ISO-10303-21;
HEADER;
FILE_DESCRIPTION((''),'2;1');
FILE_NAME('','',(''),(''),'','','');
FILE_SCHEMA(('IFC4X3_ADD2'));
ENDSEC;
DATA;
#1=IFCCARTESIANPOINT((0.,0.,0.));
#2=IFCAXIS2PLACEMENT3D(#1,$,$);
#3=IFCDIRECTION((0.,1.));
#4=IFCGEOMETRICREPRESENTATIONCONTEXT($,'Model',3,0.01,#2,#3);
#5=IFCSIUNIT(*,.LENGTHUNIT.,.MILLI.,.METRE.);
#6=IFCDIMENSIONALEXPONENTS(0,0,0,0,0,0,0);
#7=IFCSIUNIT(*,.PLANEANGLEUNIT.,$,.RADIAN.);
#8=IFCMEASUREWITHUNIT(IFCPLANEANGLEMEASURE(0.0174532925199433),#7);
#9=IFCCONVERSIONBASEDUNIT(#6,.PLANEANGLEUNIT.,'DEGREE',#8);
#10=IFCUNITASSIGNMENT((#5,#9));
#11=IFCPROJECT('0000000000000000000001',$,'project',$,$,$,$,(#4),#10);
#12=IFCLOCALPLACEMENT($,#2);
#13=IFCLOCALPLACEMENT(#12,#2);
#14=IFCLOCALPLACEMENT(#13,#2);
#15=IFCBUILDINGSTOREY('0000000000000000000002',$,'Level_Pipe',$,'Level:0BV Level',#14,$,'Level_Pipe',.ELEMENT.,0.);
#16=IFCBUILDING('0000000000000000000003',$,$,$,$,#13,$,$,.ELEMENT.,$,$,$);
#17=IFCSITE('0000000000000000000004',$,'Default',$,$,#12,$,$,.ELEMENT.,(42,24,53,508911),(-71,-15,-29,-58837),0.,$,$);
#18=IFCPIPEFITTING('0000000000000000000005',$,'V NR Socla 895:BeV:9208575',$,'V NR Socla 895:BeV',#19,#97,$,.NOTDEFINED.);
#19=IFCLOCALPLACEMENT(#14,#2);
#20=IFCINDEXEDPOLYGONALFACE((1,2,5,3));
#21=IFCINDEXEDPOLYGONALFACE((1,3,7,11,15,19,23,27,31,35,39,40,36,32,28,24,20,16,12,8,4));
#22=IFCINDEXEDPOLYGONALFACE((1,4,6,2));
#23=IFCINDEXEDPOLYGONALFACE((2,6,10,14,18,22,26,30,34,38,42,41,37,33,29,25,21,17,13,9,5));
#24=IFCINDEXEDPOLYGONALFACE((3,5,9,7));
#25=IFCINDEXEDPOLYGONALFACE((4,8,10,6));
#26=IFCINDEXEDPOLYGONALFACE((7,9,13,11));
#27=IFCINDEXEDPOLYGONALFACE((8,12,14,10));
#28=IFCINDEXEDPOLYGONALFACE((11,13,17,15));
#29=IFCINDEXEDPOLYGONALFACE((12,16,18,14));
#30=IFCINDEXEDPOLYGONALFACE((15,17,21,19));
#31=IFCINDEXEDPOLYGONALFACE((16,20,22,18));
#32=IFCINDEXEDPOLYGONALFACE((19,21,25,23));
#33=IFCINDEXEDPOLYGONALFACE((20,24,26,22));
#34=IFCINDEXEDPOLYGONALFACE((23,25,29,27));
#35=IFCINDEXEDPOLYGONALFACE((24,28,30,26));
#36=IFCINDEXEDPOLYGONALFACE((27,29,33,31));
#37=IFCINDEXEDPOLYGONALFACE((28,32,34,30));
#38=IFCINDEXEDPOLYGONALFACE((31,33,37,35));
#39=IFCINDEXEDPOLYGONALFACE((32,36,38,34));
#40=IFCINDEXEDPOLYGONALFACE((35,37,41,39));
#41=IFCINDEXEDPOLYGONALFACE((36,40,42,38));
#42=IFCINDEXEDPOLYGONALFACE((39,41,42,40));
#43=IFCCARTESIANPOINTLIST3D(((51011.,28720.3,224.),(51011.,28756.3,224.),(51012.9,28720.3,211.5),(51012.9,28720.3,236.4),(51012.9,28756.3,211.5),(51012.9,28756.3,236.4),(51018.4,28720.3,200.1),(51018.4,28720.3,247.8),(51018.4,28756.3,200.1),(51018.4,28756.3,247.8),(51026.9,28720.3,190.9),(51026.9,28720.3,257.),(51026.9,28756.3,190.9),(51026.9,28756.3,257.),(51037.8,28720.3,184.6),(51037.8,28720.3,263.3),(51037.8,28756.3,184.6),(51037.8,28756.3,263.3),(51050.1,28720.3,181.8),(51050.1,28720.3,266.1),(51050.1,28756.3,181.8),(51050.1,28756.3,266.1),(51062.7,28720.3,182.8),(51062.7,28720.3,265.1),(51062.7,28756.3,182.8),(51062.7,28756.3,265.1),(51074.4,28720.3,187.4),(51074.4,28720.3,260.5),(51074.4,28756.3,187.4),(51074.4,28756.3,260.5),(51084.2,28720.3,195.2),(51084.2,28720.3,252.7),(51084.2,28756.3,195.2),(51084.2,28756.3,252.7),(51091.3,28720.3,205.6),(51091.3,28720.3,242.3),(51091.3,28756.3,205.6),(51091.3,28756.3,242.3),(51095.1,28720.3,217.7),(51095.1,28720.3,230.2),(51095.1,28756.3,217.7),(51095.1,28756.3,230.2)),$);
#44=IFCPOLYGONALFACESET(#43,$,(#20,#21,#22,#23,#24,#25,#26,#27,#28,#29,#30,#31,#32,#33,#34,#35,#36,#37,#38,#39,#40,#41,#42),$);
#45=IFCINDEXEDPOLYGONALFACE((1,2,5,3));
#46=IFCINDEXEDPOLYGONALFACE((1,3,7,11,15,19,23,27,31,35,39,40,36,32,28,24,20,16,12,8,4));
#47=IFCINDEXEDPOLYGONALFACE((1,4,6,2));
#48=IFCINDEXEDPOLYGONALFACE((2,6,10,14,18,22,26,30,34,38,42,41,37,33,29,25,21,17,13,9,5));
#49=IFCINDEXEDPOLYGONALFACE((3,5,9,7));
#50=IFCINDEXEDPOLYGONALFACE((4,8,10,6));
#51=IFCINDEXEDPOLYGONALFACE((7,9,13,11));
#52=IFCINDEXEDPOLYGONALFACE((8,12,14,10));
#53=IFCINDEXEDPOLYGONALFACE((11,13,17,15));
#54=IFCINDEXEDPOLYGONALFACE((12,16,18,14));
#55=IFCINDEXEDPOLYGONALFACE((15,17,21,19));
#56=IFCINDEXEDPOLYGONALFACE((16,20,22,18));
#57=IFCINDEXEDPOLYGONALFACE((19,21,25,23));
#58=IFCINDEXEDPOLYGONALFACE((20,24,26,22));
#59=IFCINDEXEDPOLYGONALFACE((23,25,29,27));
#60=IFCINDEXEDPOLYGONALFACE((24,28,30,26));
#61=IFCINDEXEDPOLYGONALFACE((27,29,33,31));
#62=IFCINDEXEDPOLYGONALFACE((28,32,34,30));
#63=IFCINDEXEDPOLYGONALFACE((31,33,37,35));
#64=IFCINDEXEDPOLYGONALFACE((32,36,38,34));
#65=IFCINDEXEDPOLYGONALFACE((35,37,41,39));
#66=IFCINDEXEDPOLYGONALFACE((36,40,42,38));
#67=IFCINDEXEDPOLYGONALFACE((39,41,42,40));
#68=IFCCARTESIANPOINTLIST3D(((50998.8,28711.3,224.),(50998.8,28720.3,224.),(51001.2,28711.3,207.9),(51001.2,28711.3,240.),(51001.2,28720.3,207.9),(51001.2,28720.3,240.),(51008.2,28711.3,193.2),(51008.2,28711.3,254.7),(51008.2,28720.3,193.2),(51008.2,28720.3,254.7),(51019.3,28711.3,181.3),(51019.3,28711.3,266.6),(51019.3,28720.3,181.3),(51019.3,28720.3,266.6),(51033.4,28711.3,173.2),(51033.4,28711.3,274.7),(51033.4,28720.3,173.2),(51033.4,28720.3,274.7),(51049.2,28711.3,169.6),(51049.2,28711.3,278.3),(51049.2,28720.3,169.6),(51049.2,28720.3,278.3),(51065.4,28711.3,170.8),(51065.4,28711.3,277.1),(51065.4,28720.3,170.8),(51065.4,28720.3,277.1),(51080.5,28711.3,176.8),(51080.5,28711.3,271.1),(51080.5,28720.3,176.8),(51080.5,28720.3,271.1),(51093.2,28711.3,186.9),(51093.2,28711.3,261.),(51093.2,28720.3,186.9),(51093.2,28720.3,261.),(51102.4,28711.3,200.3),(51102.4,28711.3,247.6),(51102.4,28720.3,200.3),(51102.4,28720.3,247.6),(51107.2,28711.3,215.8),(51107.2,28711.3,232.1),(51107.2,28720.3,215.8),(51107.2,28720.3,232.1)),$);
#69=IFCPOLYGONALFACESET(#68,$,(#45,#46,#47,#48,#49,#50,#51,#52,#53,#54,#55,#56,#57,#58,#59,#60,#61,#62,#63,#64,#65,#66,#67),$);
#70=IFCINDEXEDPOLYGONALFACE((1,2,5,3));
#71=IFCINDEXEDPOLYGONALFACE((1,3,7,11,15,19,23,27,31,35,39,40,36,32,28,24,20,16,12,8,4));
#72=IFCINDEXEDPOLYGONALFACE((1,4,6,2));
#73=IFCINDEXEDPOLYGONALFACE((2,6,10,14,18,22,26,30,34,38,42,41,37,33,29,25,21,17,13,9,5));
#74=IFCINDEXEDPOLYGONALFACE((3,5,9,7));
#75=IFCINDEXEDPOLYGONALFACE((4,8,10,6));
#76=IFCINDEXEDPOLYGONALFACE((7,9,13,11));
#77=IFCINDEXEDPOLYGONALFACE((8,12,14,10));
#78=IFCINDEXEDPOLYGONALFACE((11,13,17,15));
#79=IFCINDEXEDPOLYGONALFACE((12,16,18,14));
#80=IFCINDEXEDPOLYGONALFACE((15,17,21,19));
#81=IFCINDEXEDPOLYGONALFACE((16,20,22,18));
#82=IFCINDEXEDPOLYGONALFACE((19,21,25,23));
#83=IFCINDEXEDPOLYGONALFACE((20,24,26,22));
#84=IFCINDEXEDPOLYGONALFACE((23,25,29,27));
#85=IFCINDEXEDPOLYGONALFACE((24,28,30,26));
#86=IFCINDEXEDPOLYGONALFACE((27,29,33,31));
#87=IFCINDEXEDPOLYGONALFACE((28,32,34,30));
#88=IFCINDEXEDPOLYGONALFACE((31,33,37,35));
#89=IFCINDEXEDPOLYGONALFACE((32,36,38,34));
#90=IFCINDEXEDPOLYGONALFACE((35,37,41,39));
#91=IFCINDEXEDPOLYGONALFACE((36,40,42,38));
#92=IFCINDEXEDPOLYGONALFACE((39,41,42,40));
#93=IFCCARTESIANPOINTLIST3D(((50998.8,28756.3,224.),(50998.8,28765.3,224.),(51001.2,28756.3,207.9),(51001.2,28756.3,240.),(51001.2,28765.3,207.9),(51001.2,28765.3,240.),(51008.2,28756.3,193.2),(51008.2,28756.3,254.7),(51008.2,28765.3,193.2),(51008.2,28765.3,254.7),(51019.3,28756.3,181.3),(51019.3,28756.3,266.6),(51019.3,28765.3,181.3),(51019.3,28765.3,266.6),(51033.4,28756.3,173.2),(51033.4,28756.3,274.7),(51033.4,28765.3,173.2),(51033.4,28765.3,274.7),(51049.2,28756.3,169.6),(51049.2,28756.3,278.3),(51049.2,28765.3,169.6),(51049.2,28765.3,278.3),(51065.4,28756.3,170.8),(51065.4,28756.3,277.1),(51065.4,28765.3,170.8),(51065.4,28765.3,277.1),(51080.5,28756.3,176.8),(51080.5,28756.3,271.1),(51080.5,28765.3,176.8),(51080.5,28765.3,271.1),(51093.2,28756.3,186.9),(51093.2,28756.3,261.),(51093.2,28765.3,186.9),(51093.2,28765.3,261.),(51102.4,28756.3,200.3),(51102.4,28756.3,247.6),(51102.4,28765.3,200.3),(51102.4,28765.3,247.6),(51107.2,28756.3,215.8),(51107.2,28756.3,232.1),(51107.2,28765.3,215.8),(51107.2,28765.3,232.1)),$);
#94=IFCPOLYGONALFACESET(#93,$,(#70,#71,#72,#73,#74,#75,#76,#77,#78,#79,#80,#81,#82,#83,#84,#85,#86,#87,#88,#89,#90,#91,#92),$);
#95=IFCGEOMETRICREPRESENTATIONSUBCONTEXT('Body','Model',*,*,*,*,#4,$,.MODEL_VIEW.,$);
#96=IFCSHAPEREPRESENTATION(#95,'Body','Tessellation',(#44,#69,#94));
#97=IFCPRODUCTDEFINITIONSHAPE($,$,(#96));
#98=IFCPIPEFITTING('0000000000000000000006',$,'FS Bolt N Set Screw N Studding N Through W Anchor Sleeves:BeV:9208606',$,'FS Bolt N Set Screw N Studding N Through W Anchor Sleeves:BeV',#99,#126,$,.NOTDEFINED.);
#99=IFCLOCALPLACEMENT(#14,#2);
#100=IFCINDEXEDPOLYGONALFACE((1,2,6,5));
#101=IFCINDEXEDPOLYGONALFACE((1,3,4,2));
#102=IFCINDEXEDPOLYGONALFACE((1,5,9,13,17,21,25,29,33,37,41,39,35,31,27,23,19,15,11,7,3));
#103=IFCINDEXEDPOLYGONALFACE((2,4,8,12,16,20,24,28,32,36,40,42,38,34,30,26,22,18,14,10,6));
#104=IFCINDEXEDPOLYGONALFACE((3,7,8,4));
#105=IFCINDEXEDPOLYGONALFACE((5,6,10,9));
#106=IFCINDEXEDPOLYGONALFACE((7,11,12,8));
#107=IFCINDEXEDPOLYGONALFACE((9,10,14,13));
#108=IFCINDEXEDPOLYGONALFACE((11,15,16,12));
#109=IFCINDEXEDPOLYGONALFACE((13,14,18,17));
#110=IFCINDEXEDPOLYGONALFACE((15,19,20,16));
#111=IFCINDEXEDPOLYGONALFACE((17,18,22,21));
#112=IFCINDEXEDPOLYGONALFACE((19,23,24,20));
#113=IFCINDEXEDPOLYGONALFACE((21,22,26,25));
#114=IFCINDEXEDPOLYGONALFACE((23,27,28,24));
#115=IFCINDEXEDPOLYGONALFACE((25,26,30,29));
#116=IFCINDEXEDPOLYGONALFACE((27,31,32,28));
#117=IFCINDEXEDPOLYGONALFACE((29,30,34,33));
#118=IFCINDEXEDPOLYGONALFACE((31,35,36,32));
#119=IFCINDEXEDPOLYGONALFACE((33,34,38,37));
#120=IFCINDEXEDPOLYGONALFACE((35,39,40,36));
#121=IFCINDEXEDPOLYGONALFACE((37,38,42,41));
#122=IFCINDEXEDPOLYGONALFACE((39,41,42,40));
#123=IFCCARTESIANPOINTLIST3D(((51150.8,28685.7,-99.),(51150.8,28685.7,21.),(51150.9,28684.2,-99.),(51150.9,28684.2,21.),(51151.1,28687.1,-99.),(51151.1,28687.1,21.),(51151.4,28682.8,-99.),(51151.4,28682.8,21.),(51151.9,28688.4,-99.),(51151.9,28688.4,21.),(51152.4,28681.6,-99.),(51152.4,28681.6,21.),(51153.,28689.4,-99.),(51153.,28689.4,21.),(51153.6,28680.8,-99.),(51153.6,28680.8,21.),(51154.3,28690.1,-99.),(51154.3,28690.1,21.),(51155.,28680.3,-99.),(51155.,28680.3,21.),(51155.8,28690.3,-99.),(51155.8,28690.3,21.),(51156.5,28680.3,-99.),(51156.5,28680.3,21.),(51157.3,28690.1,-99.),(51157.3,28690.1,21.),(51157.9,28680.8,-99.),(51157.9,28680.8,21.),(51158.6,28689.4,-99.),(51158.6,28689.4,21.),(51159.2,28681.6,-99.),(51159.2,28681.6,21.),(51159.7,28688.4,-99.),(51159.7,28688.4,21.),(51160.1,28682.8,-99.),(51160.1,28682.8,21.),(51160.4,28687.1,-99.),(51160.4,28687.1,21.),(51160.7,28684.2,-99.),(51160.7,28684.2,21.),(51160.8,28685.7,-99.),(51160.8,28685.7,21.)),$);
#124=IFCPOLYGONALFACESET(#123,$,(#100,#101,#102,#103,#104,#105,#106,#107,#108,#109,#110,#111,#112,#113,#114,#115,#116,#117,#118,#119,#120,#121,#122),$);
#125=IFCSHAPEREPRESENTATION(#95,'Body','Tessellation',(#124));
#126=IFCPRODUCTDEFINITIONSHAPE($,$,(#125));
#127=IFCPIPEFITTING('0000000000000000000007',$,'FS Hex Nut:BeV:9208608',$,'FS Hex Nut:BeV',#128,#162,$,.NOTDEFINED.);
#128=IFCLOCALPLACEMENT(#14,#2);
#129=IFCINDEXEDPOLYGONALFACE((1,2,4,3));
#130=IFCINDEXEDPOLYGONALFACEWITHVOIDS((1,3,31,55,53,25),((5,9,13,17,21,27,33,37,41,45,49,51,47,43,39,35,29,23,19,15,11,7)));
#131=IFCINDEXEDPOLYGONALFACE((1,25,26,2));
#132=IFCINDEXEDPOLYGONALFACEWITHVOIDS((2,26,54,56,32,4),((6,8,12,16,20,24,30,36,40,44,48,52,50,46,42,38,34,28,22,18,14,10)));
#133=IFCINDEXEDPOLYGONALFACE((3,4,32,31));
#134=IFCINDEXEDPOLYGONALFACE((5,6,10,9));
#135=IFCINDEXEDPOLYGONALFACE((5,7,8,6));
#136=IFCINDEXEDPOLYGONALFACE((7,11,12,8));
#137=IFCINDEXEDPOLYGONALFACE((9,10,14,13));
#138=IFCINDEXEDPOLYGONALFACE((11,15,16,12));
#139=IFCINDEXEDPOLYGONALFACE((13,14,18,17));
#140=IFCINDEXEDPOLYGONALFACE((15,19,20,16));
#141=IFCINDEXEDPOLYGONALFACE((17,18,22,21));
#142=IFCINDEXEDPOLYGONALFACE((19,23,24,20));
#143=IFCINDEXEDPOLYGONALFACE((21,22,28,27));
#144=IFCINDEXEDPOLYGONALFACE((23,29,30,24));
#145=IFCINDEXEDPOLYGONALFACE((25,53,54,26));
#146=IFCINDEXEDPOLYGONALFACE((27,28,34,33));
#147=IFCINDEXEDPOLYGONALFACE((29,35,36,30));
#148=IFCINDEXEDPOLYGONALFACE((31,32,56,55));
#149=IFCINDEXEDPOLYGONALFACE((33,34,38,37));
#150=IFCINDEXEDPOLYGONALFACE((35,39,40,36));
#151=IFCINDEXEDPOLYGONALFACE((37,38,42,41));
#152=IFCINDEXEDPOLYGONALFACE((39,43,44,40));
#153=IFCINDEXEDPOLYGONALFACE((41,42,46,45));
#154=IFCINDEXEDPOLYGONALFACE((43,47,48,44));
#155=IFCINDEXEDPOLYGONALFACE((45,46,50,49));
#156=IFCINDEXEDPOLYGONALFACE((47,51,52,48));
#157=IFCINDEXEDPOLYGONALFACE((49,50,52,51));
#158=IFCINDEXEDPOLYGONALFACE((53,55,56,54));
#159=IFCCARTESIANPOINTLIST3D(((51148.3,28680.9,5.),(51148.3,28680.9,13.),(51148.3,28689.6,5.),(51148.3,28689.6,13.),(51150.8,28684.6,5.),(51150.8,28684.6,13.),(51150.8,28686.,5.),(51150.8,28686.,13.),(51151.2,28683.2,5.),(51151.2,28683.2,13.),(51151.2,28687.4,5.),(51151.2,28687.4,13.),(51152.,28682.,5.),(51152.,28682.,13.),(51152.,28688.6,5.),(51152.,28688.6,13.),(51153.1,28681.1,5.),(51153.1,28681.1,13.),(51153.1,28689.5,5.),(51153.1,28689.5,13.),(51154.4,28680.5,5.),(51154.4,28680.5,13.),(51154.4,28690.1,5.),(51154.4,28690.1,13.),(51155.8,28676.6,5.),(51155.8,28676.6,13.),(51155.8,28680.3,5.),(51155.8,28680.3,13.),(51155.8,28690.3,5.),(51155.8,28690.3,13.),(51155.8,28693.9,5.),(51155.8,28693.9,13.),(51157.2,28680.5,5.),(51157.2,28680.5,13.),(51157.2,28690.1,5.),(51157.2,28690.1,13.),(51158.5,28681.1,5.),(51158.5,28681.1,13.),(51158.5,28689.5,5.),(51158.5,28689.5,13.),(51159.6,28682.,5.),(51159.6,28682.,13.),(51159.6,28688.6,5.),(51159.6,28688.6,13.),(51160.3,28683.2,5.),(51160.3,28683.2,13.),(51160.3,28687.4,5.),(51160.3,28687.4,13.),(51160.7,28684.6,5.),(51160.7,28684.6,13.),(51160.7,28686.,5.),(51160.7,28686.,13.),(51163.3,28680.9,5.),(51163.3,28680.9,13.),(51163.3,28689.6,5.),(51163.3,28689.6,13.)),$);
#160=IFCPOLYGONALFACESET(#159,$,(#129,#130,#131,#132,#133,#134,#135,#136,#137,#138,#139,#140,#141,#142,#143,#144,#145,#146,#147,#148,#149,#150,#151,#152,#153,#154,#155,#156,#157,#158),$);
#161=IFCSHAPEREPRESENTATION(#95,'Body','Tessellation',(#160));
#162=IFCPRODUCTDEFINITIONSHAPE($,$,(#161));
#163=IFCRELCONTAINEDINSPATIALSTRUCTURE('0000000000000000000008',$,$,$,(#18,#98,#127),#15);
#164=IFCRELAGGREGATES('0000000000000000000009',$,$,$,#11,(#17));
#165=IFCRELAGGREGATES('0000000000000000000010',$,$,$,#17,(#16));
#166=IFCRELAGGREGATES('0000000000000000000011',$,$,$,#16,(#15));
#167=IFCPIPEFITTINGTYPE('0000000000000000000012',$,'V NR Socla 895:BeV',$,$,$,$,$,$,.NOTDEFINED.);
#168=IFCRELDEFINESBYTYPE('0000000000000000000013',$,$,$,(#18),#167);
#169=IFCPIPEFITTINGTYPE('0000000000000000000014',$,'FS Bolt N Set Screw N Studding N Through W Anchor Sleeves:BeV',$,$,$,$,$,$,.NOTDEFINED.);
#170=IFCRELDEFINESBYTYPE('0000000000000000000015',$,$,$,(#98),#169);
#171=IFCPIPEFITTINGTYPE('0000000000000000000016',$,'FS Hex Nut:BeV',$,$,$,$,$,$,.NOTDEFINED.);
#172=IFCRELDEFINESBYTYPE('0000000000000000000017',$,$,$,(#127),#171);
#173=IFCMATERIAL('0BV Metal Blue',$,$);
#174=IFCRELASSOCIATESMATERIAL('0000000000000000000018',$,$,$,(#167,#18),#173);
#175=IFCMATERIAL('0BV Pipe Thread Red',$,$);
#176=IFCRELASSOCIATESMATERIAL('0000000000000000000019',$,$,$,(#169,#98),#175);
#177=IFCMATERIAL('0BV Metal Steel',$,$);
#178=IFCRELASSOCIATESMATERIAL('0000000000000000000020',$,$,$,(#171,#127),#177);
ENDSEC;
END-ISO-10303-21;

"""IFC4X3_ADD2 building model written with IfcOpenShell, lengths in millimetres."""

from ifc_helpers import new_model, entity, si_unit, converted_unit, direction, frame, frame_2d, origin, place, context, subcontext, project, spatial, polyline, circle_curve, parameter, trimmed, segment, composite_curve, circle, outline, extrude, source, transform, mapped, material, type_object, type_shapes, element, save


model = new_model("IFC4X3_ADD2")

# Units and contexts
model_context = context("Model", 3, precision=0.01, world=origin(), true_north=direction((0.0, 1.0)))
body_context = subcontext(model_context, "Body", "Model", "MODEL_VIEW")
ifc_project = project(units=[si_unit("LENGTHUNIT", "METRE", prefix="MILLI"), converted_unit("PLANEANGLEUNIT", "DEGREE", entity("IfcPlaneAngleMeasure", 0.0174532925199433), si_unit("PLANEANGLEUNIT", "RADIAN"), dimensions=[0, 0, 0, 0, 0, 0, 0])], contexts=[model_context])

# Site, building, storey
site_placement = place(None, origin())
site = spatial("IfcSite", under=ifc_project, at=site_placement, Name="Default", CompositionType="ELEMENT", RefLatitude=(42, 24, 53, 508911), RefLongitude=(-71, -15, -29, -58837), RefElevation=0.0)
building_placement = place(site_placement, origin())
building = spatial("IfcBuilding", under=site, at=building_placement, CompositionType="ELEMENT")
storey_placement = place(building_placement, origin())
storey = spatial("IfcBuildingStorey", under=building, at=storey_placement, Name="Level_Pipe", ObjectType="Level:0BV Level", LongName="Level_Pipe", CompositionType="ELEMENT", Elevation=0.0)

# Pipe fittings
ifc_material_1 = material(Name="0BV Metal Blue")
ifc_material_2 = material(Name="0BV Metal Steel")
pipe_fitting_type_1 = type_object("IfcPipeFittingType", Name="V NR Socla 895:BeV", PredefinedType="NOTDEFINED", material=ifc_material_1)
shared_shape_1 = source(origin(), body_context, "Body", "SweptSolid", [
    extrude(circle(Radius=42.2, at=frame_2d((0.0, 0.0), x_axis=(1.0, 0.0))), frame((-18.0, 0.0, 0.0), z_axis=(1.0, 0.0, 0.0), x_axis=(0.0, 1.0, 0.0)), (0.0, 0.0, 1.0), 36.0),
    extrude(circle(Radius=54.5, at=frame_2d((0.0, 0.0), x_axis=(1.0, 0.0))), frame((18.0, 0.0, 0.0), z_axis=(1.0, 0.0, 0.0), x_axis=(0.0, 1.0, 0.0)), (0.0, 0.0, 1.0), 9.0),
    extrude(circle(Radius=54.5, at=frame_2d((0.0, 0.0), x_axis=(1.0, 0.0))), frame((-27.0, 0.0, 0.0), z_axis=(1.0, 0.0, 0.0), x_axis=(0.0, 1.0, 0.0)), (0.0, 0.0, 1.0), 9.0),
])
type_shapes(pipe_fitting_type_1, [shared_shape_1])
pipe_fitting_1_placement = place(storey_placement, frame((51053.3, 28738.3, 223.9), z_axis=(0.0, 0.0, -1.0), x_axis=(0.0, -1.0, 0.0)))
element("IfcPipeFitting", 1, at=pipe_fitting_1_placement, inside=storey, type_object=pipe_fitting_type_1, material=ifc_material_1, Name="V NR Socla 895:BeV:9208575", ObjectType="V NR Socla 895:BeV", PredefinedType="NOTDEFINED", context=body_context, shape_type="MappedRepresentation", body=[
    mapped(shared_shape_1, transform((0.0, 0.0, 0.0), scale=1.0)),
])
ifc_material_3 = material(Name="0BV Pipe Thread Red")
pipe_fitting_type_2 = type_object("IfcPipeFittingType", Name="FS Bolt N Set Screw N Studding N Through W Anchor Sleeves:BeV", PredefinedType="NOTDEFINED", material=ifc_material_3)
shared_shape_2 = source(origin(), body_context, "Body", "SweptSolid", [
    extrude(circle(Radius=5.0, at=frame_2d((0.0, 0.0), x_axis=(1.0, 0.0))), frame((-16.0, 0.0, 0.0), z_axis=(1.0, 0.0, 0.0), x_axis=(0.0, 1.0, 0.0)), (0.0, 0.0, 1.0), 120.0),
])
type_shapes(pipe_fitting_type_2, [shared_shape_2])
pipe_fitting_2_placement = place(storey_placement, frame((51155.8, 28685.3, 5.0), z_axis=(1.0, 0.0, 0.0), x_axis=(0.0, 0.0, -1.0)))
element("IfcPipeFitting", 2, at=pipe_fitting_2_placement, inside=storey, type_object=pipe_fitting_type_2, material=ifc_material_3, Name="FS Bolt N Set Screw N Studding N Through W Anchor Sleeves:BeV:9208606", ObjectType="FS Bolt N Set Screw N Studding N Through W Anchor Sleeves:BeV", PredefinedType="NOTDEFINED", context=body_context, shape_type="MappedRepresentation", body=[
    mapped(shared_shape_2, transform((0.0, 0.0, 0.0), scale=1.0)),
])
pipe_fitting_type_3 = type_object("IfcPipeFittingType", Name="FS Hex Nut:BeV", PredefinedType="NOTDEFINED", material=ifc_material_2)
shared_shape_3 = source(origin(), body_context, "Body", "SweptSolid", [
    extrude(outline(polyline([(-4.3, -7.5), (4.3, -7.5), (8.7, 0.0), (4.3, 7.5), (-4.3, 7.5), (-8.7, 0.0), (-4.3, -7.5)]), holes=[composite_curve([segment(trimmed(circle_curve(frame_2d((0.0, 0.0), x_axis=(-0.5, 0.866025)), 5.0), [parameter(0.0)], [parameter(180.0)], True, "PARAMETER"), False, "CONTINUOUS"), segment(trimmed(circle_curve(frame_2d((0.0, 0.0), x_axis=(-0.5, 0.866025)), 5.0), [parameter(180.0)], [parameter(360.0)], True, "PARAMETER"), False, "CONTINUOUS")], self_intersect=False)]), frame((0.0, 8.7, 7.5), z_axis=(1.0, 0.0, 0.0), x_axis=(0.0, -0.5, -0.866025)), (0.0, 0.0, 1.0), 8.0),
])
type_shapes(pipe_fitting_type_3, [shared_shape_3])
pipe_fitting_3_placement = place(storey_placement, frame((51148.3, 28676.6, 13.0), z_axis=(1.0, 0.0, 0.0), x_axis=(0.0, 0.0, -1.0)))
element("IfcPipeFitting", 3, at=pipe_fitting_3_placement, inside=storey, type_object=pipe_fitting_type_3, material=ifc_material_2, Name="FS Hex Nut:BeV:9208608", ObjectType="FS Hex Nut:BeV", PredefinedType="NOTDEFINED", context=body_context, shape_type="MappedRepresentation", body=[
    mapped(shared_shape_3, transform((0.0, 0.0, 0.0), scale=1.0)),
])

save(model, "model.ifc")
